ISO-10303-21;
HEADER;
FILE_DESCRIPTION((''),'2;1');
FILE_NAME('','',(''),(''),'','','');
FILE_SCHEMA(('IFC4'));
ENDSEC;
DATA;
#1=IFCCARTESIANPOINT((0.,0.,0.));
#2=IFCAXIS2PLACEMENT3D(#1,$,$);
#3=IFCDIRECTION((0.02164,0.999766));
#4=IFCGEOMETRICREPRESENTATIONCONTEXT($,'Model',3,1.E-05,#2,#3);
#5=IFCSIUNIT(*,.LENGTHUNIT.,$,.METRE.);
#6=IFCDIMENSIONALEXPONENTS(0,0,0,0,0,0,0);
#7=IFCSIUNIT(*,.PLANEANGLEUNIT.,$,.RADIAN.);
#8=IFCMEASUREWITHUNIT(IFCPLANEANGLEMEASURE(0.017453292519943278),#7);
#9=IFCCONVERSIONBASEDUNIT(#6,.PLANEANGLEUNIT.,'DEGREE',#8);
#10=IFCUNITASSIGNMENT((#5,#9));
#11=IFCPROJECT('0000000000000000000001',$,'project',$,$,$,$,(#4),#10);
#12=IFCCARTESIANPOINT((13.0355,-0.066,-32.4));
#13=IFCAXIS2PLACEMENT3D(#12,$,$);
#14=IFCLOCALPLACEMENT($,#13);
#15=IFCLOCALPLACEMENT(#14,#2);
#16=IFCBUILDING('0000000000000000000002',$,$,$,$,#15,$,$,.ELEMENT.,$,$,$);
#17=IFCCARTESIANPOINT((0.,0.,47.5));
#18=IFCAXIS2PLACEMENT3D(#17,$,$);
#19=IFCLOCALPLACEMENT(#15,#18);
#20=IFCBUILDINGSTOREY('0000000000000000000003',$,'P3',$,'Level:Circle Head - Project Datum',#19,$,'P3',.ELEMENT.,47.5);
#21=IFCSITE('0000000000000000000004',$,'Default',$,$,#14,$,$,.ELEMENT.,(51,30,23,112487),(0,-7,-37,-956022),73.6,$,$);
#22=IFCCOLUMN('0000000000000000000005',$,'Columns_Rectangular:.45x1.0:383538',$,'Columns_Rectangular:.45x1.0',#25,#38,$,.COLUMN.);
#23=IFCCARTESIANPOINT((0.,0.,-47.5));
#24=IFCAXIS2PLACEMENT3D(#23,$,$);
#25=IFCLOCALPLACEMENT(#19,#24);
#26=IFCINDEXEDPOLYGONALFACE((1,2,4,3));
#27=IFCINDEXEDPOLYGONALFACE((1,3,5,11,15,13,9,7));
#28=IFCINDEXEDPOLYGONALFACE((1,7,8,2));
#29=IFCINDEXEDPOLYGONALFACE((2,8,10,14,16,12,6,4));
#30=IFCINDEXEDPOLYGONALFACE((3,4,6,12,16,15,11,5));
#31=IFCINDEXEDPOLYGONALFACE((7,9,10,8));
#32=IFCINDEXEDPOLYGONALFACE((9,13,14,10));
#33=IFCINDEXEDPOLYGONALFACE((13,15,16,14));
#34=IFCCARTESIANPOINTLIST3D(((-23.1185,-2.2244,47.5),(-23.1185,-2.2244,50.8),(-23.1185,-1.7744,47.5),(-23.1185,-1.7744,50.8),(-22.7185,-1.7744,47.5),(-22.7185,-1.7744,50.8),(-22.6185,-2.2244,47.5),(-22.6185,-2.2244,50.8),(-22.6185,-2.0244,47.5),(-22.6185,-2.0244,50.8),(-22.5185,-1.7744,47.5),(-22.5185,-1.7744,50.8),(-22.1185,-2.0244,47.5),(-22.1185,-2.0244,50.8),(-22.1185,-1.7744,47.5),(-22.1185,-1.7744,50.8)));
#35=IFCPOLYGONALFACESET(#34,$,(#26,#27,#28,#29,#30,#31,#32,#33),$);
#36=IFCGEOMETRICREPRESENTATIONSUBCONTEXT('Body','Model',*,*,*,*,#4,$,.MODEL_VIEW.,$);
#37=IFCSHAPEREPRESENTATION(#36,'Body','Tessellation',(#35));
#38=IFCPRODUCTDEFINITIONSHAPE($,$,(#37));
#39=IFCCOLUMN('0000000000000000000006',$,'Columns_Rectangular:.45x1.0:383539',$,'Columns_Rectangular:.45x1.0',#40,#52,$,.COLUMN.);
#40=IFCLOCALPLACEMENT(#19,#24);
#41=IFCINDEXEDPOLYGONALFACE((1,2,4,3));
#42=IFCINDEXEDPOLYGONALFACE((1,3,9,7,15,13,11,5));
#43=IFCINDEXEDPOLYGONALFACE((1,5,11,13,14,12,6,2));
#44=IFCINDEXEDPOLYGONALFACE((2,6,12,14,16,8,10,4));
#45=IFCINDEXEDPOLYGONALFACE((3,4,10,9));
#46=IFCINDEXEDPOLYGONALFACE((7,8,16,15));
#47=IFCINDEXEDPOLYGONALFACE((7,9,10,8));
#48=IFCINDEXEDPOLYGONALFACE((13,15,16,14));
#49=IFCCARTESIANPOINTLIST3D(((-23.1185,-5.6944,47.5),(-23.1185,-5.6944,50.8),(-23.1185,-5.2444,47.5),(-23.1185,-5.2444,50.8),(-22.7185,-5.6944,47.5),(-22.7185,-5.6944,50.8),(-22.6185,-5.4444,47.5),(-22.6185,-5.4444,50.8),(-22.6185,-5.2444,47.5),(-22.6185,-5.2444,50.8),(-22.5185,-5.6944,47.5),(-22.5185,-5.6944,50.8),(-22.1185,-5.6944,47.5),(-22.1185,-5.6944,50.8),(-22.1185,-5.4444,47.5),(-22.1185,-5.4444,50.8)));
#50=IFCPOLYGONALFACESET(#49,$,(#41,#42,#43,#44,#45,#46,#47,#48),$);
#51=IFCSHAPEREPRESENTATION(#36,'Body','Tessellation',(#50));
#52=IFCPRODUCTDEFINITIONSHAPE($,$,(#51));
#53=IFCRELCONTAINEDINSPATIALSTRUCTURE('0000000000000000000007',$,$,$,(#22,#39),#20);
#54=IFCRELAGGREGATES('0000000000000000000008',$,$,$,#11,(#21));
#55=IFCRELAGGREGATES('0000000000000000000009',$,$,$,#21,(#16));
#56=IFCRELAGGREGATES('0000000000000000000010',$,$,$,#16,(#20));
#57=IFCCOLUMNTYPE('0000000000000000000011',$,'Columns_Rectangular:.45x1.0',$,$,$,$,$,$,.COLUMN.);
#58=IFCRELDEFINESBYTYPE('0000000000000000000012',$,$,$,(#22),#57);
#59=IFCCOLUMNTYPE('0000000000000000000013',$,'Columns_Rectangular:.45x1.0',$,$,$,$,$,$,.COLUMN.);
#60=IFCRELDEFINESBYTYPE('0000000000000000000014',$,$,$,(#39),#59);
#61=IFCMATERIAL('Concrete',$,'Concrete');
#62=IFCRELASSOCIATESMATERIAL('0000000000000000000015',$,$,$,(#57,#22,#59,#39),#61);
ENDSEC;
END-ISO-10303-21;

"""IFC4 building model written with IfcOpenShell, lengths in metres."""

from ifc_helpers import new_model, entity, si_unit, converted_unit, direction, frame, origin, place, context, subcontext, project, spatial, indexed_curve, outline, extrude, source, transform, mapped, material, type_object, type_shapes, element, save


model = new_model("IFC4")

# Units and contexts
model_context = context("Model", 3, precision=1e-05, world=origin(), true_north=direction((0.02164, 0.999766)))
body_context = subcontext(model_context, "Body", "Model", "MODEL_VIEW")
ifc_project = project(units=[si_unit("LENGTHUNIT", "METRE"), converted_unit("PLANEANGLEUNIT", "DEGREE", entity("IfcPlaneAngleMeasure", 0.017453292519943278), si_unit("PLANEANGLEUNIT", "RADIAN"), dimensions=[0, 0, 0, 0, 0, 0, 0])], contexts=[model_context])

# Site, building, storey
site_placement = place(None, frame((13.0355, -0.066, -32.4)))
site = spatial("IfcSite", under=ifc_project, at=site_placement, Name="Default", CompositionType="ELEMENT", RefLatitude=(51, 30, 23, 112487), RefLongitude=(0, -7, -37, -956022), RefElevation=73.6)
building_placement = place(site_placement, origin())
building = spatial("IfcBuilding", under=site, at=building_placement, CompositionType="ELEMENT")
storey_placement = place(building_placement, frame((0.0, 0.0, 47.5)))
storey = spatial("IfcBuildingStorey", under=building, at=storey_placement, Name="P3", ObjectType="Level:Circle Head - Project Datum", LongName="P3", CompositionType="ELEMENT", Elevation=47.5)

# Columns
ifc_material = material(Name="Concrete", Category="Concrete")
column_type_1 = type_object("IfcColumnType", Name="Columns_Rectangular:.45x1.0", PredefinedType="COLUMN", material=ifc_material)
shared_shape_1 = source(origin(), body_context, "Body", "SweptSolid", [
    extrude(outline(indexed_curve([(-0.5, -0.275), (0.0, -0.275), (0.0, -0.075), (0.5, -0.075), (0.5, 0.175), (0.1, 0.175), (-0.1, 0.175), (-0.5, 0.175), (-0.5, -0.275)], self_intersect=False)), frame((-22.6185, -1.9494, 47.5)), (0.0, 0.0, 1.0), 3.3),
])
type_shapes(column_type_1, [shared_shape_1])
column_1_placement = place(storey_placement, frame((0.0, 0.0, -47.5)))
element("IfcColumn", 1, at=column_1_placement, inside=storey, type_object=column_type_1, material=ifc_material, Name="Columns_Rectangular:.45x1.0:383538", ObjectType="Columns_Rectangular:.45x1.0", PredefinedType="COLUMN", context=body_context, shape_type="MappedRepresentation", body=[
    mapped(shared_shape_1, transform((0.0, 0.0, 0.0), scale=1.0)),
])
column_type_2 = type_object("IfcColumnType", Name="Columns_Rectangular:.45x1.0", PredefinedType="COLUMN", material=ifc_material)
shared_shape_2 = source(origin(), body_context, "Body", "SweptSolid", [
    extrude(outline(indexed_curve([(-0.175, -0.5), (0.075, -0.5), (0.075, 0.0), (0.275, 0.0), (0.275, 0.5), (-0.175, 0.5), (-0.175, 0.1), (-0.175, -0.1), (-0.175, -0.5)], self_intersect=False)), frame((-22.6185, -5.5194, 47.5), z_axis=(0.0, 0.0, 1.0), x_axis=(0.0, 1.0, 0.0)), (0.0, 0.0, 1.0), 3.3),
])
type_shapes(column_type_2, [shared_shape_2])
column_2_placement = place(storey_placement, frame((0.0, 0.0, -47.5)))
element("IfcColumn", 2, at=column_2_placement, inside=storey, type_object=column_type_2, material=ifc_material, Name="Columns_Rectangular:.45x1.0:383539", ObjectType="Columns_Rectangular:.45x1.0", PredefinedType="COLUMN", context=body_context, shape_type="MappedRepresentation", body=[
    mapped(shared_shape_2, transform((0.0, 0.0, 0.0), scale=1.0)),
])

save(model, "model.ifc")
